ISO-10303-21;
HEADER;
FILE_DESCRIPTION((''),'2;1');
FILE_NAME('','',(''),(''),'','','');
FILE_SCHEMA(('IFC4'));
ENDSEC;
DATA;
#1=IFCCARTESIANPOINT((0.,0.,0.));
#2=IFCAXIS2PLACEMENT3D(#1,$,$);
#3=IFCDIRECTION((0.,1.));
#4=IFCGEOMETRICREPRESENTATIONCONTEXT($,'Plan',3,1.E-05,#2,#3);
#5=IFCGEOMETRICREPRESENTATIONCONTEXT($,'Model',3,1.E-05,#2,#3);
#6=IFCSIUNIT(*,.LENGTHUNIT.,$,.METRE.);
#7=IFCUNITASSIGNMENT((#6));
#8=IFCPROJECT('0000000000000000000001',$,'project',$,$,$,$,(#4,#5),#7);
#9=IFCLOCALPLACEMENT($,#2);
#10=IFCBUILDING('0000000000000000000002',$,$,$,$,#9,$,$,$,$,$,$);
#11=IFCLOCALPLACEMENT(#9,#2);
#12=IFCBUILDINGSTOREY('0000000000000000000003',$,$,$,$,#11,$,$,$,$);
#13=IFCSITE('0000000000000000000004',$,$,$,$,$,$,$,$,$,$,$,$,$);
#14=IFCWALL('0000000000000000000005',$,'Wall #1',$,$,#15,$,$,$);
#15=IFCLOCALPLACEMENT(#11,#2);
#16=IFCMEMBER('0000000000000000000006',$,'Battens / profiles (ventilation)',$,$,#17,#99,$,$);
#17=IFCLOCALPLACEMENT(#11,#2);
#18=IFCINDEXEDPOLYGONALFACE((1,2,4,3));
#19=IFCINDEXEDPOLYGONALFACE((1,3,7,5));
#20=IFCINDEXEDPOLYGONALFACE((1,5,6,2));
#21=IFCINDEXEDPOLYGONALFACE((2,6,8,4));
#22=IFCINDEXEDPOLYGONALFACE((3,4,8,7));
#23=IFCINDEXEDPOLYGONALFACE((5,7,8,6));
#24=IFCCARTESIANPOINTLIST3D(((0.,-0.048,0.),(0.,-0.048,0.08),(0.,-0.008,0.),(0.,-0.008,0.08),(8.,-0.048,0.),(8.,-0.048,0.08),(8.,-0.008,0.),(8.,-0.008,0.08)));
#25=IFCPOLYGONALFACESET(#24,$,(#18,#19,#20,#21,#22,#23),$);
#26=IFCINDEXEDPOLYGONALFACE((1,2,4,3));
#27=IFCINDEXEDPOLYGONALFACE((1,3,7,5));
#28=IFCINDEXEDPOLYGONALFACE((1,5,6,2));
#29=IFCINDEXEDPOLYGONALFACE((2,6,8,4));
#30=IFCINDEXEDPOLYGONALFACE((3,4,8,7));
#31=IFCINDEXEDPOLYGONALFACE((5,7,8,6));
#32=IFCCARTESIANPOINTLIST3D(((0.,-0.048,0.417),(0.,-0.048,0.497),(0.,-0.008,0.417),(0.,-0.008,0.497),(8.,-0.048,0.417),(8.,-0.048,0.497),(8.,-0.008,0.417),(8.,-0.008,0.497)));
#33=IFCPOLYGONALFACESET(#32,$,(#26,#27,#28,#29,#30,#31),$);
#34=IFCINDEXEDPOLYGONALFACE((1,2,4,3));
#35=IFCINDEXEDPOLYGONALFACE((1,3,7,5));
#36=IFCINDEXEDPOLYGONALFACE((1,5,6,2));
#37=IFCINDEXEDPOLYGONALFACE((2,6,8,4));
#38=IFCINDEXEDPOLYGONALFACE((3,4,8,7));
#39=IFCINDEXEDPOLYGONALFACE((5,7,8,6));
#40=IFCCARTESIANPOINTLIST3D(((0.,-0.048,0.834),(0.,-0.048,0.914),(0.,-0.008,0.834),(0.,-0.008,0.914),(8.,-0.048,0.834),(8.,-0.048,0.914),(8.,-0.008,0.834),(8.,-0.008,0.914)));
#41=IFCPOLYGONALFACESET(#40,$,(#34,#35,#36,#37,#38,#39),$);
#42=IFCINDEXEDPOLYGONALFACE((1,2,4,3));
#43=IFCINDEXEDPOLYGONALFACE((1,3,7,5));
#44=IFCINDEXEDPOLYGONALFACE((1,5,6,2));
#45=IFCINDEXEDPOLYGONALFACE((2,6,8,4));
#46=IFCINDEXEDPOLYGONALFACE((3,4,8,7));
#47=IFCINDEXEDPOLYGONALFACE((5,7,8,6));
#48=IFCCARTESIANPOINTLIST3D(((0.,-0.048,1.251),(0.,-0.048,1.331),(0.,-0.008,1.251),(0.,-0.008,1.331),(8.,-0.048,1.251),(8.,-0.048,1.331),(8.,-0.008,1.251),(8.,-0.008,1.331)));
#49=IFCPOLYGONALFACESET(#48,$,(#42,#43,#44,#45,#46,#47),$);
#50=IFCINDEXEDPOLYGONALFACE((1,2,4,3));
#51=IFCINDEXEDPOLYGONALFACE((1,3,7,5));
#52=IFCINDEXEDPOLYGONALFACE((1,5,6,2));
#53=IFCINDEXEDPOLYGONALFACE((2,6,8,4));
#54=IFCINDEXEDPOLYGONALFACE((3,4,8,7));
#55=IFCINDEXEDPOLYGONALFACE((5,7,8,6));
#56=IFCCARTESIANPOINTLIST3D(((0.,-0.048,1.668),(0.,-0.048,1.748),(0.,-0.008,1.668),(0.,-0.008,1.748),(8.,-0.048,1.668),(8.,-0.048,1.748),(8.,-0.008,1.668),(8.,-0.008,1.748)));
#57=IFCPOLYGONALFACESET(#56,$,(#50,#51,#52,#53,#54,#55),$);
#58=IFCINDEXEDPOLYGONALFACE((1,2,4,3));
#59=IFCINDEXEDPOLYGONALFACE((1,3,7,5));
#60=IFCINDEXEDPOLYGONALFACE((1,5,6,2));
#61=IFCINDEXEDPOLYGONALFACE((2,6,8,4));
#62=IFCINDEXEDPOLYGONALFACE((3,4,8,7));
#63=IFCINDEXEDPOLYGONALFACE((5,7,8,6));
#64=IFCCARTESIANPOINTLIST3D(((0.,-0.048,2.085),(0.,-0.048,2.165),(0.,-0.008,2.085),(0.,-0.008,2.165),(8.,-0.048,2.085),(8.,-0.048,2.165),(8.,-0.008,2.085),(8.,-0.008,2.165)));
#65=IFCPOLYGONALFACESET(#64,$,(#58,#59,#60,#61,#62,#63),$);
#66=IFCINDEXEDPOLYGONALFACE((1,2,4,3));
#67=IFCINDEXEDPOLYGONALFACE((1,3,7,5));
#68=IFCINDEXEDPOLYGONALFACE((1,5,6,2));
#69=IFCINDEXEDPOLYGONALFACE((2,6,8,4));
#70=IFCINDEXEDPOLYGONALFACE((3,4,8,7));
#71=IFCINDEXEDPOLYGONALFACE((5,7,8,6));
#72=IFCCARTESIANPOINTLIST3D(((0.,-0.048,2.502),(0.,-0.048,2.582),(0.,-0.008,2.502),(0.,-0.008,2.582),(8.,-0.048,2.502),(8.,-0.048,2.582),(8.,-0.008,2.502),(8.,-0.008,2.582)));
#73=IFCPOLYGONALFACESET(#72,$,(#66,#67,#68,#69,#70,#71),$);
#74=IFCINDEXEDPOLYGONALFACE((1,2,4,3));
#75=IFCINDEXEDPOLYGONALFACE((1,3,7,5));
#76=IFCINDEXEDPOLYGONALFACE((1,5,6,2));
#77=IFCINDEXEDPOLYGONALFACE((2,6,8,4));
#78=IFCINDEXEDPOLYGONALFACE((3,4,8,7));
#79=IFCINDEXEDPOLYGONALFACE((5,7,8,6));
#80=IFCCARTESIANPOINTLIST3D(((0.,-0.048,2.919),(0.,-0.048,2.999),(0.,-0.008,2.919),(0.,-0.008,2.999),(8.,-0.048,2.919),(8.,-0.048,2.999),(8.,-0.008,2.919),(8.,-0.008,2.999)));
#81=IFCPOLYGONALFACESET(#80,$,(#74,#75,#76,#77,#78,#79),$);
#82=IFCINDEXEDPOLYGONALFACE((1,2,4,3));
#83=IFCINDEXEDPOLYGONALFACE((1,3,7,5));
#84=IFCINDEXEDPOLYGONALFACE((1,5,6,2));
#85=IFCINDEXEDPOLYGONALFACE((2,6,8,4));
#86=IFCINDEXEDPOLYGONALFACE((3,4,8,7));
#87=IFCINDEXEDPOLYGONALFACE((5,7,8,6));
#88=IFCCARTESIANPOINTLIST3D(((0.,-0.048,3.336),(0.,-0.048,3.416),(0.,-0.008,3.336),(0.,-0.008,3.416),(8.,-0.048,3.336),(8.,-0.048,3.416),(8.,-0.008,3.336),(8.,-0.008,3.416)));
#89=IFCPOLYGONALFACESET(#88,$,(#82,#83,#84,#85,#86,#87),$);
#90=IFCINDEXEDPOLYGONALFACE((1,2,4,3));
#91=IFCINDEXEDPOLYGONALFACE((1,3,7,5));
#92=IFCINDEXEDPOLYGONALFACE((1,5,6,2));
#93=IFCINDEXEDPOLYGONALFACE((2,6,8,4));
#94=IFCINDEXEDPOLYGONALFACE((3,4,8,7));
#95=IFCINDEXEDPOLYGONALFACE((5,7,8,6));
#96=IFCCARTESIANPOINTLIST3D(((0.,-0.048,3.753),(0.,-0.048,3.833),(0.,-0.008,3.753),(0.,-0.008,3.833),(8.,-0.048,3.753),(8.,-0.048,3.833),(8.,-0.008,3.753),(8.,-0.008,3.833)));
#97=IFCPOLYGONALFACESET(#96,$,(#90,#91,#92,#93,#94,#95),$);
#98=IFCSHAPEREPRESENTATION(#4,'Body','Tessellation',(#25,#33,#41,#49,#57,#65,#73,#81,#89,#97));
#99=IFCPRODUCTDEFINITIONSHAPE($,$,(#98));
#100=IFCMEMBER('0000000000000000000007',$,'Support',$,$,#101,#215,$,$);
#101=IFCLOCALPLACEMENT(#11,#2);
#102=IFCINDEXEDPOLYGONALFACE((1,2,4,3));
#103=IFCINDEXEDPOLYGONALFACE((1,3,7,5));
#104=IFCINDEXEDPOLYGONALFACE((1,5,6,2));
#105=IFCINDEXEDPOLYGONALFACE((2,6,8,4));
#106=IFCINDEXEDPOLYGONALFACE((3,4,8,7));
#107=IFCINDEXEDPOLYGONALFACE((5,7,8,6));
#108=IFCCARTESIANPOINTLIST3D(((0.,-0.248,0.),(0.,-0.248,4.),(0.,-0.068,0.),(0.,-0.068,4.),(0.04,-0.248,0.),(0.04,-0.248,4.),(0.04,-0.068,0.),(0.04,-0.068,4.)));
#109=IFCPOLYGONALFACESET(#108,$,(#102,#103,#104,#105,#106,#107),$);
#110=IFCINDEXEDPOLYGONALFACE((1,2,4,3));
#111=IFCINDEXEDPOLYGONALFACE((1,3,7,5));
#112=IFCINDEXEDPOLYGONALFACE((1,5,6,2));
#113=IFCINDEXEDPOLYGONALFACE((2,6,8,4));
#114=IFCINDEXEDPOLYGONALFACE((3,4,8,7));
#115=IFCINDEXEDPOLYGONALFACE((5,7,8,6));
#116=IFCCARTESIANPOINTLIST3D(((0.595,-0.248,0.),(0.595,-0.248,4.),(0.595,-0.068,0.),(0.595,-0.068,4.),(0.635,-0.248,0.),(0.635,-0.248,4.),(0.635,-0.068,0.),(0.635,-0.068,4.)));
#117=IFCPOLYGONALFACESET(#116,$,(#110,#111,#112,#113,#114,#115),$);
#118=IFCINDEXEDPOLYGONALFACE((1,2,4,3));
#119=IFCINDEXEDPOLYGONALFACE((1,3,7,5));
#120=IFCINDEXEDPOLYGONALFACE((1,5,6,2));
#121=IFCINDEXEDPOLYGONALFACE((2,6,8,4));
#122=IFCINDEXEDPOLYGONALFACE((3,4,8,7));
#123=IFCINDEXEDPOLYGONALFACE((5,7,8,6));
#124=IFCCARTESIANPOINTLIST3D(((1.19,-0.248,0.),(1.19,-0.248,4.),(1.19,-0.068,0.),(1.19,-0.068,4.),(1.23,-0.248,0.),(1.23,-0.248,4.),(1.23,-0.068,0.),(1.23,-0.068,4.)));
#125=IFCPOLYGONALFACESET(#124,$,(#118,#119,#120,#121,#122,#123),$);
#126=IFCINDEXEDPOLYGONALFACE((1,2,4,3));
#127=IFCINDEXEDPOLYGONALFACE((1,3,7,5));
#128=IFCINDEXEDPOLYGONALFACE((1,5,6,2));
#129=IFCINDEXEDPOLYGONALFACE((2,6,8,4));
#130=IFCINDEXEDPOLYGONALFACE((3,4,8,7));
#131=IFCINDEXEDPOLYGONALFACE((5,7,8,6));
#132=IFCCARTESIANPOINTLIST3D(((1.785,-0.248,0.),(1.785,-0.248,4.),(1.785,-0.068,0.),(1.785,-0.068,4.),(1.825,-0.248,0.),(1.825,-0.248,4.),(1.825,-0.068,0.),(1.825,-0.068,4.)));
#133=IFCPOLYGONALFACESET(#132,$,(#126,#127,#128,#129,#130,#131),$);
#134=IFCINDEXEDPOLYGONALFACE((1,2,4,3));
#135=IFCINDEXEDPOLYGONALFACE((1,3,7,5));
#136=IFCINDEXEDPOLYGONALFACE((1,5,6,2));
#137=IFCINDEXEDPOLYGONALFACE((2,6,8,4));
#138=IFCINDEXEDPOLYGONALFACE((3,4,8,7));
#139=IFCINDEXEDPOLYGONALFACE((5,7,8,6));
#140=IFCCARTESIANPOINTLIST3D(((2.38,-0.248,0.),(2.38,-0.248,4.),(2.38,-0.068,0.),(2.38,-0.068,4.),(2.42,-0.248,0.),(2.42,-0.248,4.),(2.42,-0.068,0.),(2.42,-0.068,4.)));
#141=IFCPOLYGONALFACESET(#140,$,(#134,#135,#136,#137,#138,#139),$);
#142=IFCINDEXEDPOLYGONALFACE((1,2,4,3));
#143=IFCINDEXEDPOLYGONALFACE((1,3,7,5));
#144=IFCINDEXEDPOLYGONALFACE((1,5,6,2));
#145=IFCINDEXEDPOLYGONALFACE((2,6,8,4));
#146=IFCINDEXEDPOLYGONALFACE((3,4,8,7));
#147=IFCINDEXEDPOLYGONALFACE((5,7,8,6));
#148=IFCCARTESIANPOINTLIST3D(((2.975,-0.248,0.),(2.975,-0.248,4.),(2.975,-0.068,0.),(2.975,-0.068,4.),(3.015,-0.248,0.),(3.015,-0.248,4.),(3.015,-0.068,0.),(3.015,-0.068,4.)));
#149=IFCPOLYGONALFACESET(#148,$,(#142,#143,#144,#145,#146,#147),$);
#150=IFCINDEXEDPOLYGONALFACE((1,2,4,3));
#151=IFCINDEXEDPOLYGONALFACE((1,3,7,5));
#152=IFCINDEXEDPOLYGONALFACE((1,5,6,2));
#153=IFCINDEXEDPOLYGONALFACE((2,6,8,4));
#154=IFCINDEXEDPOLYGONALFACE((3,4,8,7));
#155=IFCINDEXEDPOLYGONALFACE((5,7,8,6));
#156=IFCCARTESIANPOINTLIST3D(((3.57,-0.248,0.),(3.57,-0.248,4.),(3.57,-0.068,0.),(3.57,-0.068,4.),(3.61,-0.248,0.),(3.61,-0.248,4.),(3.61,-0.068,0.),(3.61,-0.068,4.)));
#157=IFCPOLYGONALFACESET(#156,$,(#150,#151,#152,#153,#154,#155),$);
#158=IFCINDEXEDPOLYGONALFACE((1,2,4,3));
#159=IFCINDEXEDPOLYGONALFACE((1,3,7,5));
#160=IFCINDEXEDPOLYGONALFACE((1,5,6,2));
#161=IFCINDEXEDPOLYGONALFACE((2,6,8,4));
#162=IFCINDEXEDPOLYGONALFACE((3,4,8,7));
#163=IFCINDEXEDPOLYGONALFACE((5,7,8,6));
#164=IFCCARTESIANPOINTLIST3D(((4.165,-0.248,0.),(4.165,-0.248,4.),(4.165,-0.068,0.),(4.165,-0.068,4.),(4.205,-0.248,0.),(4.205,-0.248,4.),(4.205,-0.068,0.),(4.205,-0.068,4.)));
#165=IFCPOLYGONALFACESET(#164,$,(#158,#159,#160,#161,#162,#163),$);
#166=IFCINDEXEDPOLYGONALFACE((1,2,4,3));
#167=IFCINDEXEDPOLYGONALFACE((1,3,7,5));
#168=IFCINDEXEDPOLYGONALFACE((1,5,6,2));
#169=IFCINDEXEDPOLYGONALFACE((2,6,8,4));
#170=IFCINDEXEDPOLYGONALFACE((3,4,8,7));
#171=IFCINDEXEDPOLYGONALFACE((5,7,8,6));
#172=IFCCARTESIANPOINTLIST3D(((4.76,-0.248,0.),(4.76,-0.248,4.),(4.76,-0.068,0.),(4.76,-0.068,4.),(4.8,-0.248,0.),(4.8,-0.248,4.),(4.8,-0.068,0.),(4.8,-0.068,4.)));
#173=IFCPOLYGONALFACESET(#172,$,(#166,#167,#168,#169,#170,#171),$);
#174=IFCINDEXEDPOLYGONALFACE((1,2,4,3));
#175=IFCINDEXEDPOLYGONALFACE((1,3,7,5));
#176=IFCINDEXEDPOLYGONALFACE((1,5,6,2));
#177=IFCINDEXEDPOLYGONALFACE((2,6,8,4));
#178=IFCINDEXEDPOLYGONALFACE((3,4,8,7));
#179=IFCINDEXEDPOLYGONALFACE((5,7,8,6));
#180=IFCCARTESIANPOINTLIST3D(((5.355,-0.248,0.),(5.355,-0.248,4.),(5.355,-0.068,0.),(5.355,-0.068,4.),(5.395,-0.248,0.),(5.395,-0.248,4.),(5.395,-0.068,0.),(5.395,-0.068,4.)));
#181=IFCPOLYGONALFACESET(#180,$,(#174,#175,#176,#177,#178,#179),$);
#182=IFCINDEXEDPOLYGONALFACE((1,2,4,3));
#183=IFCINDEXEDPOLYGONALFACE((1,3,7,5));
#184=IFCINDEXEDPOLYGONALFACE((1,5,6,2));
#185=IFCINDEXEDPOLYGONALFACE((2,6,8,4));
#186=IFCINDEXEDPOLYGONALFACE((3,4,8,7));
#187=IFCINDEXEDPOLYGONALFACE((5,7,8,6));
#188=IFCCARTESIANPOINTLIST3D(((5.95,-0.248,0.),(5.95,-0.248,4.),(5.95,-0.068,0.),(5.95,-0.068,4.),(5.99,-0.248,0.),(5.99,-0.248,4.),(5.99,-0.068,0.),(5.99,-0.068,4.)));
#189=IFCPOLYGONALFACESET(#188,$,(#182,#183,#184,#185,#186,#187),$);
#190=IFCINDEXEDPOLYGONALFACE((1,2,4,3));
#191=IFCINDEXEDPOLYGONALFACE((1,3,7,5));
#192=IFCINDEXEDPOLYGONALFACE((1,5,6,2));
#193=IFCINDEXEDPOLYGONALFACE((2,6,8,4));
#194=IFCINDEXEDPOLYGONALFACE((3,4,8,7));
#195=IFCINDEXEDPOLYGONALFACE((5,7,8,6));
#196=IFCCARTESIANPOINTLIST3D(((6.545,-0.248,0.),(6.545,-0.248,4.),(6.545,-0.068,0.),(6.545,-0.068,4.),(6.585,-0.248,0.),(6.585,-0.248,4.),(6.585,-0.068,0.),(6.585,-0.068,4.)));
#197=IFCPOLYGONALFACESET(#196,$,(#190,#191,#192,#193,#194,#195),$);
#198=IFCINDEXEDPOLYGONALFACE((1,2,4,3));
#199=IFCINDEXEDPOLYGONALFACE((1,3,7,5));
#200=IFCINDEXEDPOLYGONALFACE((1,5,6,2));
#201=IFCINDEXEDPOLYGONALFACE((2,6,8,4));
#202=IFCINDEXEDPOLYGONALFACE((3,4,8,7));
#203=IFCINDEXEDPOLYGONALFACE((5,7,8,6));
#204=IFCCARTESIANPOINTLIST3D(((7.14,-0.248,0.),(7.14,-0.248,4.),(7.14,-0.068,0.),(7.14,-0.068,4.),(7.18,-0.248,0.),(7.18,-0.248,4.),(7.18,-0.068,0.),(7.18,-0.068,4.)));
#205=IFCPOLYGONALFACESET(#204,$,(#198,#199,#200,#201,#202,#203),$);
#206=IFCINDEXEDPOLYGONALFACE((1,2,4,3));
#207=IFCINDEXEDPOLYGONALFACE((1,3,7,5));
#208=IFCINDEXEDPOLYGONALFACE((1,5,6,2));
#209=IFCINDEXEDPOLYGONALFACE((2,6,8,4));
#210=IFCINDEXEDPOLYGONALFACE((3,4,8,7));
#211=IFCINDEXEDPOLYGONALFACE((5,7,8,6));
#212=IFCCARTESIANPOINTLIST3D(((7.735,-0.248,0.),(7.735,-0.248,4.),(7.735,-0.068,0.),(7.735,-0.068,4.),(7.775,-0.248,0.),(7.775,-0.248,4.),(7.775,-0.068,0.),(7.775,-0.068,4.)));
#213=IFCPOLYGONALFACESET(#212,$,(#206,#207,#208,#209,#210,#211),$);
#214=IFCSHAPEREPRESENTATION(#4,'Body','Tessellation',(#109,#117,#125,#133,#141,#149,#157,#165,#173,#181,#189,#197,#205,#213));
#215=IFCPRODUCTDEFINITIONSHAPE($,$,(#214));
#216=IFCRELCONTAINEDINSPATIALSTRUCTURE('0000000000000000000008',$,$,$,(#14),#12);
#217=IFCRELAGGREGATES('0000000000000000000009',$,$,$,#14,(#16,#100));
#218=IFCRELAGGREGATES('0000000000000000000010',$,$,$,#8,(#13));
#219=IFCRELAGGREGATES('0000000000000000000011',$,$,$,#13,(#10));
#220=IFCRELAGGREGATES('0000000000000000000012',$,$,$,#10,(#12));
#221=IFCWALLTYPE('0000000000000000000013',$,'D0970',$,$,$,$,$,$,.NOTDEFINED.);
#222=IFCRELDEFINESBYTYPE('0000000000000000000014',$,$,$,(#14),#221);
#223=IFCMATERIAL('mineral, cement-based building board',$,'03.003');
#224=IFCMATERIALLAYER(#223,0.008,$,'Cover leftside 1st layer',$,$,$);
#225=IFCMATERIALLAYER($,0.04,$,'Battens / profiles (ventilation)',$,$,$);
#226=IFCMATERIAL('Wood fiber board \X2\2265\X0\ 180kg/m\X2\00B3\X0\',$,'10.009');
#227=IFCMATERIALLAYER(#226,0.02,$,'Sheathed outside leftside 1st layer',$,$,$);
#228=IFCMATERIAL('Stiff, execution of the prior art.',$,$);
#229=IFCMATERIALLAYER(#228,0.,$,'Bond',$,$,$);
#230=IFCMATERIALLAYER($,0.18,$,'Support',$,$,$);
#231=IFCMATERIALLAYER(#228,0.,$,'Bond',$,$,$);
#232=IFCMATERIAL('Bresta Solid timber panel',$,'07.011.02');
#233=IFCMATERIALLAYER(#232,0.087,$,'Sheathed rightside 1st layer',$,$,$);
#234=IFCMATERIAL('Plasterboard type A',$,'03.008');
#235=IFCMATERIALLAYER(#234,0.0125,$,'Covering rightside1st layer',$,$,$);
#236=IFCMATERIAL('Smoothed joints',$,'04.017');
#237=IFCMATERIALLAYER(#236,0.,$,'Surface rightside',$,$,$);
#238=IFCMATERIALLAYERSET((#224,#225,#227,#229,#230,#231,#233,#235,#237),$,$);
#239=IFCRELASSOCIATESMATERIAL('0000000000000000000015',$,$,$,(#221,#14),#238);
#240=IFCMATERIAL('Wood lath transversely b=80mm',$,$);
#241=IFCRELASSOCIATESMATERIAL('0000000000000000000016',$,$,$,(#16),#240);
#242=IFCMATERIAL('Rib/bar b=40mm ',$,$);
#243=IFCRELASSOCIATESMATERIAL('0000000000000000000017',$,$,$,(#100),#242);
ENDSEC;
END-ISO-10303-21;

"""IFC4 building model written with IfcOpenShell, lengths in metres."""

from ifc_helpers import new_model, si_unit, direction, frame, frame_2d, origin, place, context, project, spatial, rectangle, extrude, material, layer, layer_set, type_object, element, aggregate, save


model = new_model("IFC4")

# Units and contexts
plan_context = context("Plan", 3, precision=1e-05, world=origin(), true_north=direction((0.0, 1.0)))
model_context = context("Model", 3, precision=1e-05, world=origin(), true_north=direction((0.0, 1.0)))
ifc_project = project(units=[si_unit("LENGTHUNIT", "METRE")], contexts=[plan_context, model_context])

# Site, building, storey
site = spatial("IfcSite", under=ifc_project)
building_placement = place(None, origin())
building = spatial("IfcBuilding", under=site, at=building_placement)
storey_placement = place(building_placement, origin())
storey = spatial("IfcBuildingStorey", under=building, at=storey_placement)

# Wall, members
ifc_material_1 = material(Name="mineral, cement-based building board", Category="03.003")
ifc_layer_1 = layer(ifc_material_1, 0.008, Name="Cover leftside 1st layer")
ifc_layer_2 = layer(None, 0.04, Name="Battens / profiles (ventilation)")
ifc_material_2 = material(Name="Wood fiber board ≥ 180kg/m³", Category="10.009")
ifc_layer_3 = layer(ifc_material_2, 0.02, Name="Sheathed outside leftside 1st layer")
ifc_material_3 = material(Name="Stiff, execution of the prior art.")
ifc_layer_4 = layer(ifc_material_3, 0.0, Name="Bond")
ifc_layer_5 = layer(None, 0.18, Name="Support")
ifc_layer_6 = layer(ifc_material_3, 0.0, Name="Bond")
ifc_material_4 = material(Name="Bresta Solid timber panel", Category="07.011.02")
ifc_layer_7 = layer(ifc_material_4, 0.087, Name="Sheathed rightside 1st layer")
ifc_material_5 = material(Name="Plasterboard type A", Category="03.008")
ifc_layer_8 = layer(ifc_material_5, 0.0125, Name="Covering rightside1st layer")
ifc_material_6 = material(Name="Smoothed joints", Category="04.017")
ifc_layer_9 = layer(ifc_material_6, 0.0, Name="Surface rightside")
ifc_layer_set = layer_set([ifc_layer_1, ifc_layer_2, ifc_layer_3, ifc_layer_4, ifc_layer_5, ifc_layer_6, ifc_layer_7, ifc_layer_8, ifc_layer_9])
wall_type = type_object("IfcWallType", Name="D0970", PredefinedType="NOTDEFINED", material=ifc_layer_set)
wall_placement = place(None, frame((0.0, 0.0, 0.0), z_axis=(0.0, -1.0, 0.0), x_axis=(1.0, 0.0, 0.0)))
wall = element("IfcWall", 1, at=wall_placement, inside=storey, type_object=wall_type, material=ifc_layer_set, Name="Wall #1")
ifc_material_7 = material(Name="Wood lath transversely b=80mm")
member_1_placement = place(wall_placement, origin())
member_1 = element("IfcMember", 2, at=member_1_placement, material=ifc_material_7, Name="Battens / profiles (ventilation)", context=plan_context, shape_type="SweptSolid", body=[
    extrude(rectangle(XDim=0.08, YDim=0.04, at=frame_2d((0.04, 0.02), x_axis=(1.0, 0.0))), frame((0.0, 0.0, 0.008), z_axis=(1.0, 0.0, 0.0), x_axis=(0.0, 1.0, 0.0)), (0.0, 0.0, 1.0), 8.0),
    extrude(rectangle(XDim=0.08, YDim=0.04, at=frame_2d((0.04, 0.02), x_axis=(1.0, 0.0))), frame((0.0, 0.417, 0.008), z_axis=(1.0, 0.0, 0.0), x_axis=(0.0, 1.0, 0.0)), (0.0, 0.0, 1.0), 8.0),
    extrude(rectangle(XDim=0.08, YDim=0.04, at=frame_2d((0.04, 0.02), x_axis=(1.0, 0.0))), frame((0.0, 0.834, 0.008), z_axis=(1.0, 0.0, 0.0), x_axis=(0.0, 1.0, 0.0)), (0.0, 0.0, 1.0), 8.0),
    extrude(rectangle(XDim=0.08, YDim=0.04, at=frame_2d((0.04, 0.02), x_axis=(1.0, 0.0))), frame((0.0, 1.251, 0.008), z_axis=(1.0, 0.0, 0.0), x_axis=(0.0, 1.0, 0.0)), (0.0, 0.0, 1.0), 8.0),
    extrude(rectangle(XDim=0.08, YDim=0.04, at=frame_2d((0.04, 0.02), x_axis=(1.0, 0.0))), frame((0.0, 1.668, 0.008), z_axis=(1.0, 0.0, 0.0), x_axis=(0.0, 1.0, 0.0)), (0.0, 0.0, 1.0), 8.0),
    extrude(rectangle(XDim=0.08, YDim=0.04, at=frame_2d((0.04, 0.02), x_axis=(1.0, 0.0))), frame((0.0, 2.085, 0.008), z_axis=(1.0, 0.0, 0.0), x_axis=(0.0, 1.0, 0.0)), (0.0, 0.0, 1.0), 8.0),
    extrude(rectangle(XDim=0.08, YDim=0.04, at=frame_2d((0.04, 0.02), x_axis=(1.0, 0.0))), frame((0.0, 2.502, 0.008), z_axis=(1.0, 0.0, 0.0), x_axis=(0.0, 1.0, 0.0)), (0.0, 0.0, 1.0), 8.0),
    extrude(rectangle(XDim=0.08, YDim=0.04, at=frame_2d((0.04, 0.02), x_axis=(1.0, 0.0))), frame((0.0, 2.919, 0.008), z_axis=(1.0, 0.0, 0.0), x_axis=(0.0, 1.0, 0.0)), (0.0, 0.0, 1.0), 8.0),
    extrude(rectangle(XDim=0.08, YDim=0.04, at=frame_2d((0.04, 0.02), x_axis=(1.0, 0.0))), frame((0.0, 3.336, 0.008), z_axis=(1.0, 0.0, 0.0), x_axis=(0.0, 1.0, 0.0)), (0.0, 0.0, 1.0), 8.0),
    extrude(rectangle(XDim=0.08, YDim=0.04, at=frame_2d((0.04, 0.02), x_axis=(1.0, 0.0))), frame((0.0, 3.753, 0.008), z_axis=(1.0, 0.0, 0.0), x_axis=(0.0, 1.0, 0.0)), (0.0, 0.0, 1.0), 8.0),
])
ifc_material_8 = material(Name="Rib/bar b=40mm ")
member_2_placement = place(wall_placement, origin())
member_2 = element("IfcMember", 3, at=member_2_placement, material=ifc_material_8, Name="Support", context=plan_context, shape_type="SweptSolid", body=[
    extrude(rectangle(XDim=0.04, YDim=0.18, at=frame_2d((0.02, 0.09), x_axis=(1.0, 0.0))), frame((0.0, 4.0, 0.068), z_axis=(0.0, -1.0, 0.0), x_axis=(1.0, 0.0, 0.0)), (0.0, 0.0, 1.0), 4.0),
    extrude(rectangle(XDim=0.04, YDim=0.18, at=frame_2d((0.02, 0.09), x_axis=(1.0, 0.0))), frame((0.595, 4.0, 0.068), z_axis=(0.0, -1.0, 0.0), x_axis=(1.0, 0.0, 0.0)), (0.0, 0.0, 1.0), 4.0),
    extrude(rectangle(XDim=0.04, YDim=0.18, at=frame_2d((0.02, 0.09), x_axis=(1.0, 0.0))), frame((1.19, 4.0, 0.068), z_axis=(0.0, -1.0, 0.0), x_axis=(1.0, 0.0, 0.0)), (0.0, 0.0, 1.0), 4.0),
    extrude(rectangle(XDim=0.04, YDim=0.18, at=frame_2d((0.02, 0.09), x_axis=(1.0, 0.0))), frame((1.785, 4.0, 0.068), z_axis=(0.0, -1.0, 0.0), x_axis=(1.0, 0.0, 0.0)), (0.0, 0.0, 1.0), 4.0),
    extrude(rectangle(XDim=0.04, YDim=0.18, at=frame_2d((0.02, 0.09), x_axis=(1.0, 0.0))), frame((2.38, 4.0, 0.068), z_axis=(0.0, -1.0, 0.0), x_axis=(1.0, 0.0, 0.0)), (0.0, 0.0, 1.0), 4.0),
    extrude(rectangle(XDim=0.04, YDim=0.18, at=frame_2d((0.02, 0.09), x_axis=(1.0, 0.0))), frame((2.975, 4.0, 0.068), z_axis=(0.0, -1.0, 0.0), x_axis=(1.0, 0.0, 0.0)), (0.0, 0.0, 1.0), 4.0),
    extrude(rectangle(XDim=0.04, YDim=0.18, at=frame_2d((0.02, 0.09), x_axis=(1.0, 0.0))), frame((3.57, 4.0, 0.068), z_axis=(0.0, -1.0, 0.0), x_axis=(1.0, 0.0, 0.0)), (0.0, 0.0, 1.0), 4.0),
    extrude(rectangle(XDim=0.04, YDim=0.18, at=frame_2d((0.02, 0.09), x_axis=(1.0, 0.0))), frame((4.165, 4.0, 0.068), z_axis=(0.0, -1.0, 0.0), x_axis=(1.0, 0.0, 0.0)), (0.0, 0.0, 1.0), 4.0),
    extrude(rectangle(XDim=0.04, YDim=0.18, at=frame_2d((0.02, 0.09), x_axis=(1.0, 0.0))), frame((4.76, 4.0, 0.068), z_axis=(0.0, -1.0, 0.0), x_axis=(1.0, 0.0, 0.0)), (0.0, 0.0, 1.0), 4.0),
    extrude(rectangle(XDim=0.04, YDim=0.18, at=frame_2d((0.02, 0.09), x_axis=(1.0, 0.0))), frame((5.355, 4.0, 0.068), z_axis=(0.0, -1.0, 0.0), x_axis=(1.0, 0.0, 0.0)), (0.0, 0.0, 1.0), 4.0),
    extrude(rectangle(XDim=0.04, YDim=0.18, at=frame_2d((0.02, 0.09), x_axis=(1.0, 0.0))), frame((5.95, 4.0, 0.068), z_axis=(0.0, -1.0, 0.0), x_axis=(1.0, 0.0, 0.0)), (0.0, 0.0, 1.0), 4.0),
    extrude(rectangle(XDim=0.04, YDim=0.18, at=frame_2d((0.02, 0.09), x_axis=(1.0, 0.0))), frame((6.545, 4.0, 0.068), z_axis=(0.0, -1.0, 0.0), x_axis=(1.0, 0.0, 0.0)), (0.0, 0.0, 1.0), 4.0),
    extrude(rectangle(XDim=0.04, YDim=0.18, at=frame_2d((0.02, 0.09), x_axis=(1.0, 0.0))), frame((7.14, 4.0, 0.068), z_axis=(0.0, -1.0, 0.0), x_axis=(1.0, 0.0, 0.0)), (0.0, 0.0, 1.0), 4.0),
    extrude(rectangle(XDim=0.04, YDim=0.18, at=frame_2d((0.02, 0.09), x_axis=(1.0, 0.0))), frame((7.735, 4.0, 0.068), z_axis=(0.0, -1.0, 0.0), x_axis=(1.0, 0.0, 0.0)), (0.0, 0.0, 1.0), 4.0),
])
aggregate(wall, [member_1, member_2])

save(model, "model.ifc")
